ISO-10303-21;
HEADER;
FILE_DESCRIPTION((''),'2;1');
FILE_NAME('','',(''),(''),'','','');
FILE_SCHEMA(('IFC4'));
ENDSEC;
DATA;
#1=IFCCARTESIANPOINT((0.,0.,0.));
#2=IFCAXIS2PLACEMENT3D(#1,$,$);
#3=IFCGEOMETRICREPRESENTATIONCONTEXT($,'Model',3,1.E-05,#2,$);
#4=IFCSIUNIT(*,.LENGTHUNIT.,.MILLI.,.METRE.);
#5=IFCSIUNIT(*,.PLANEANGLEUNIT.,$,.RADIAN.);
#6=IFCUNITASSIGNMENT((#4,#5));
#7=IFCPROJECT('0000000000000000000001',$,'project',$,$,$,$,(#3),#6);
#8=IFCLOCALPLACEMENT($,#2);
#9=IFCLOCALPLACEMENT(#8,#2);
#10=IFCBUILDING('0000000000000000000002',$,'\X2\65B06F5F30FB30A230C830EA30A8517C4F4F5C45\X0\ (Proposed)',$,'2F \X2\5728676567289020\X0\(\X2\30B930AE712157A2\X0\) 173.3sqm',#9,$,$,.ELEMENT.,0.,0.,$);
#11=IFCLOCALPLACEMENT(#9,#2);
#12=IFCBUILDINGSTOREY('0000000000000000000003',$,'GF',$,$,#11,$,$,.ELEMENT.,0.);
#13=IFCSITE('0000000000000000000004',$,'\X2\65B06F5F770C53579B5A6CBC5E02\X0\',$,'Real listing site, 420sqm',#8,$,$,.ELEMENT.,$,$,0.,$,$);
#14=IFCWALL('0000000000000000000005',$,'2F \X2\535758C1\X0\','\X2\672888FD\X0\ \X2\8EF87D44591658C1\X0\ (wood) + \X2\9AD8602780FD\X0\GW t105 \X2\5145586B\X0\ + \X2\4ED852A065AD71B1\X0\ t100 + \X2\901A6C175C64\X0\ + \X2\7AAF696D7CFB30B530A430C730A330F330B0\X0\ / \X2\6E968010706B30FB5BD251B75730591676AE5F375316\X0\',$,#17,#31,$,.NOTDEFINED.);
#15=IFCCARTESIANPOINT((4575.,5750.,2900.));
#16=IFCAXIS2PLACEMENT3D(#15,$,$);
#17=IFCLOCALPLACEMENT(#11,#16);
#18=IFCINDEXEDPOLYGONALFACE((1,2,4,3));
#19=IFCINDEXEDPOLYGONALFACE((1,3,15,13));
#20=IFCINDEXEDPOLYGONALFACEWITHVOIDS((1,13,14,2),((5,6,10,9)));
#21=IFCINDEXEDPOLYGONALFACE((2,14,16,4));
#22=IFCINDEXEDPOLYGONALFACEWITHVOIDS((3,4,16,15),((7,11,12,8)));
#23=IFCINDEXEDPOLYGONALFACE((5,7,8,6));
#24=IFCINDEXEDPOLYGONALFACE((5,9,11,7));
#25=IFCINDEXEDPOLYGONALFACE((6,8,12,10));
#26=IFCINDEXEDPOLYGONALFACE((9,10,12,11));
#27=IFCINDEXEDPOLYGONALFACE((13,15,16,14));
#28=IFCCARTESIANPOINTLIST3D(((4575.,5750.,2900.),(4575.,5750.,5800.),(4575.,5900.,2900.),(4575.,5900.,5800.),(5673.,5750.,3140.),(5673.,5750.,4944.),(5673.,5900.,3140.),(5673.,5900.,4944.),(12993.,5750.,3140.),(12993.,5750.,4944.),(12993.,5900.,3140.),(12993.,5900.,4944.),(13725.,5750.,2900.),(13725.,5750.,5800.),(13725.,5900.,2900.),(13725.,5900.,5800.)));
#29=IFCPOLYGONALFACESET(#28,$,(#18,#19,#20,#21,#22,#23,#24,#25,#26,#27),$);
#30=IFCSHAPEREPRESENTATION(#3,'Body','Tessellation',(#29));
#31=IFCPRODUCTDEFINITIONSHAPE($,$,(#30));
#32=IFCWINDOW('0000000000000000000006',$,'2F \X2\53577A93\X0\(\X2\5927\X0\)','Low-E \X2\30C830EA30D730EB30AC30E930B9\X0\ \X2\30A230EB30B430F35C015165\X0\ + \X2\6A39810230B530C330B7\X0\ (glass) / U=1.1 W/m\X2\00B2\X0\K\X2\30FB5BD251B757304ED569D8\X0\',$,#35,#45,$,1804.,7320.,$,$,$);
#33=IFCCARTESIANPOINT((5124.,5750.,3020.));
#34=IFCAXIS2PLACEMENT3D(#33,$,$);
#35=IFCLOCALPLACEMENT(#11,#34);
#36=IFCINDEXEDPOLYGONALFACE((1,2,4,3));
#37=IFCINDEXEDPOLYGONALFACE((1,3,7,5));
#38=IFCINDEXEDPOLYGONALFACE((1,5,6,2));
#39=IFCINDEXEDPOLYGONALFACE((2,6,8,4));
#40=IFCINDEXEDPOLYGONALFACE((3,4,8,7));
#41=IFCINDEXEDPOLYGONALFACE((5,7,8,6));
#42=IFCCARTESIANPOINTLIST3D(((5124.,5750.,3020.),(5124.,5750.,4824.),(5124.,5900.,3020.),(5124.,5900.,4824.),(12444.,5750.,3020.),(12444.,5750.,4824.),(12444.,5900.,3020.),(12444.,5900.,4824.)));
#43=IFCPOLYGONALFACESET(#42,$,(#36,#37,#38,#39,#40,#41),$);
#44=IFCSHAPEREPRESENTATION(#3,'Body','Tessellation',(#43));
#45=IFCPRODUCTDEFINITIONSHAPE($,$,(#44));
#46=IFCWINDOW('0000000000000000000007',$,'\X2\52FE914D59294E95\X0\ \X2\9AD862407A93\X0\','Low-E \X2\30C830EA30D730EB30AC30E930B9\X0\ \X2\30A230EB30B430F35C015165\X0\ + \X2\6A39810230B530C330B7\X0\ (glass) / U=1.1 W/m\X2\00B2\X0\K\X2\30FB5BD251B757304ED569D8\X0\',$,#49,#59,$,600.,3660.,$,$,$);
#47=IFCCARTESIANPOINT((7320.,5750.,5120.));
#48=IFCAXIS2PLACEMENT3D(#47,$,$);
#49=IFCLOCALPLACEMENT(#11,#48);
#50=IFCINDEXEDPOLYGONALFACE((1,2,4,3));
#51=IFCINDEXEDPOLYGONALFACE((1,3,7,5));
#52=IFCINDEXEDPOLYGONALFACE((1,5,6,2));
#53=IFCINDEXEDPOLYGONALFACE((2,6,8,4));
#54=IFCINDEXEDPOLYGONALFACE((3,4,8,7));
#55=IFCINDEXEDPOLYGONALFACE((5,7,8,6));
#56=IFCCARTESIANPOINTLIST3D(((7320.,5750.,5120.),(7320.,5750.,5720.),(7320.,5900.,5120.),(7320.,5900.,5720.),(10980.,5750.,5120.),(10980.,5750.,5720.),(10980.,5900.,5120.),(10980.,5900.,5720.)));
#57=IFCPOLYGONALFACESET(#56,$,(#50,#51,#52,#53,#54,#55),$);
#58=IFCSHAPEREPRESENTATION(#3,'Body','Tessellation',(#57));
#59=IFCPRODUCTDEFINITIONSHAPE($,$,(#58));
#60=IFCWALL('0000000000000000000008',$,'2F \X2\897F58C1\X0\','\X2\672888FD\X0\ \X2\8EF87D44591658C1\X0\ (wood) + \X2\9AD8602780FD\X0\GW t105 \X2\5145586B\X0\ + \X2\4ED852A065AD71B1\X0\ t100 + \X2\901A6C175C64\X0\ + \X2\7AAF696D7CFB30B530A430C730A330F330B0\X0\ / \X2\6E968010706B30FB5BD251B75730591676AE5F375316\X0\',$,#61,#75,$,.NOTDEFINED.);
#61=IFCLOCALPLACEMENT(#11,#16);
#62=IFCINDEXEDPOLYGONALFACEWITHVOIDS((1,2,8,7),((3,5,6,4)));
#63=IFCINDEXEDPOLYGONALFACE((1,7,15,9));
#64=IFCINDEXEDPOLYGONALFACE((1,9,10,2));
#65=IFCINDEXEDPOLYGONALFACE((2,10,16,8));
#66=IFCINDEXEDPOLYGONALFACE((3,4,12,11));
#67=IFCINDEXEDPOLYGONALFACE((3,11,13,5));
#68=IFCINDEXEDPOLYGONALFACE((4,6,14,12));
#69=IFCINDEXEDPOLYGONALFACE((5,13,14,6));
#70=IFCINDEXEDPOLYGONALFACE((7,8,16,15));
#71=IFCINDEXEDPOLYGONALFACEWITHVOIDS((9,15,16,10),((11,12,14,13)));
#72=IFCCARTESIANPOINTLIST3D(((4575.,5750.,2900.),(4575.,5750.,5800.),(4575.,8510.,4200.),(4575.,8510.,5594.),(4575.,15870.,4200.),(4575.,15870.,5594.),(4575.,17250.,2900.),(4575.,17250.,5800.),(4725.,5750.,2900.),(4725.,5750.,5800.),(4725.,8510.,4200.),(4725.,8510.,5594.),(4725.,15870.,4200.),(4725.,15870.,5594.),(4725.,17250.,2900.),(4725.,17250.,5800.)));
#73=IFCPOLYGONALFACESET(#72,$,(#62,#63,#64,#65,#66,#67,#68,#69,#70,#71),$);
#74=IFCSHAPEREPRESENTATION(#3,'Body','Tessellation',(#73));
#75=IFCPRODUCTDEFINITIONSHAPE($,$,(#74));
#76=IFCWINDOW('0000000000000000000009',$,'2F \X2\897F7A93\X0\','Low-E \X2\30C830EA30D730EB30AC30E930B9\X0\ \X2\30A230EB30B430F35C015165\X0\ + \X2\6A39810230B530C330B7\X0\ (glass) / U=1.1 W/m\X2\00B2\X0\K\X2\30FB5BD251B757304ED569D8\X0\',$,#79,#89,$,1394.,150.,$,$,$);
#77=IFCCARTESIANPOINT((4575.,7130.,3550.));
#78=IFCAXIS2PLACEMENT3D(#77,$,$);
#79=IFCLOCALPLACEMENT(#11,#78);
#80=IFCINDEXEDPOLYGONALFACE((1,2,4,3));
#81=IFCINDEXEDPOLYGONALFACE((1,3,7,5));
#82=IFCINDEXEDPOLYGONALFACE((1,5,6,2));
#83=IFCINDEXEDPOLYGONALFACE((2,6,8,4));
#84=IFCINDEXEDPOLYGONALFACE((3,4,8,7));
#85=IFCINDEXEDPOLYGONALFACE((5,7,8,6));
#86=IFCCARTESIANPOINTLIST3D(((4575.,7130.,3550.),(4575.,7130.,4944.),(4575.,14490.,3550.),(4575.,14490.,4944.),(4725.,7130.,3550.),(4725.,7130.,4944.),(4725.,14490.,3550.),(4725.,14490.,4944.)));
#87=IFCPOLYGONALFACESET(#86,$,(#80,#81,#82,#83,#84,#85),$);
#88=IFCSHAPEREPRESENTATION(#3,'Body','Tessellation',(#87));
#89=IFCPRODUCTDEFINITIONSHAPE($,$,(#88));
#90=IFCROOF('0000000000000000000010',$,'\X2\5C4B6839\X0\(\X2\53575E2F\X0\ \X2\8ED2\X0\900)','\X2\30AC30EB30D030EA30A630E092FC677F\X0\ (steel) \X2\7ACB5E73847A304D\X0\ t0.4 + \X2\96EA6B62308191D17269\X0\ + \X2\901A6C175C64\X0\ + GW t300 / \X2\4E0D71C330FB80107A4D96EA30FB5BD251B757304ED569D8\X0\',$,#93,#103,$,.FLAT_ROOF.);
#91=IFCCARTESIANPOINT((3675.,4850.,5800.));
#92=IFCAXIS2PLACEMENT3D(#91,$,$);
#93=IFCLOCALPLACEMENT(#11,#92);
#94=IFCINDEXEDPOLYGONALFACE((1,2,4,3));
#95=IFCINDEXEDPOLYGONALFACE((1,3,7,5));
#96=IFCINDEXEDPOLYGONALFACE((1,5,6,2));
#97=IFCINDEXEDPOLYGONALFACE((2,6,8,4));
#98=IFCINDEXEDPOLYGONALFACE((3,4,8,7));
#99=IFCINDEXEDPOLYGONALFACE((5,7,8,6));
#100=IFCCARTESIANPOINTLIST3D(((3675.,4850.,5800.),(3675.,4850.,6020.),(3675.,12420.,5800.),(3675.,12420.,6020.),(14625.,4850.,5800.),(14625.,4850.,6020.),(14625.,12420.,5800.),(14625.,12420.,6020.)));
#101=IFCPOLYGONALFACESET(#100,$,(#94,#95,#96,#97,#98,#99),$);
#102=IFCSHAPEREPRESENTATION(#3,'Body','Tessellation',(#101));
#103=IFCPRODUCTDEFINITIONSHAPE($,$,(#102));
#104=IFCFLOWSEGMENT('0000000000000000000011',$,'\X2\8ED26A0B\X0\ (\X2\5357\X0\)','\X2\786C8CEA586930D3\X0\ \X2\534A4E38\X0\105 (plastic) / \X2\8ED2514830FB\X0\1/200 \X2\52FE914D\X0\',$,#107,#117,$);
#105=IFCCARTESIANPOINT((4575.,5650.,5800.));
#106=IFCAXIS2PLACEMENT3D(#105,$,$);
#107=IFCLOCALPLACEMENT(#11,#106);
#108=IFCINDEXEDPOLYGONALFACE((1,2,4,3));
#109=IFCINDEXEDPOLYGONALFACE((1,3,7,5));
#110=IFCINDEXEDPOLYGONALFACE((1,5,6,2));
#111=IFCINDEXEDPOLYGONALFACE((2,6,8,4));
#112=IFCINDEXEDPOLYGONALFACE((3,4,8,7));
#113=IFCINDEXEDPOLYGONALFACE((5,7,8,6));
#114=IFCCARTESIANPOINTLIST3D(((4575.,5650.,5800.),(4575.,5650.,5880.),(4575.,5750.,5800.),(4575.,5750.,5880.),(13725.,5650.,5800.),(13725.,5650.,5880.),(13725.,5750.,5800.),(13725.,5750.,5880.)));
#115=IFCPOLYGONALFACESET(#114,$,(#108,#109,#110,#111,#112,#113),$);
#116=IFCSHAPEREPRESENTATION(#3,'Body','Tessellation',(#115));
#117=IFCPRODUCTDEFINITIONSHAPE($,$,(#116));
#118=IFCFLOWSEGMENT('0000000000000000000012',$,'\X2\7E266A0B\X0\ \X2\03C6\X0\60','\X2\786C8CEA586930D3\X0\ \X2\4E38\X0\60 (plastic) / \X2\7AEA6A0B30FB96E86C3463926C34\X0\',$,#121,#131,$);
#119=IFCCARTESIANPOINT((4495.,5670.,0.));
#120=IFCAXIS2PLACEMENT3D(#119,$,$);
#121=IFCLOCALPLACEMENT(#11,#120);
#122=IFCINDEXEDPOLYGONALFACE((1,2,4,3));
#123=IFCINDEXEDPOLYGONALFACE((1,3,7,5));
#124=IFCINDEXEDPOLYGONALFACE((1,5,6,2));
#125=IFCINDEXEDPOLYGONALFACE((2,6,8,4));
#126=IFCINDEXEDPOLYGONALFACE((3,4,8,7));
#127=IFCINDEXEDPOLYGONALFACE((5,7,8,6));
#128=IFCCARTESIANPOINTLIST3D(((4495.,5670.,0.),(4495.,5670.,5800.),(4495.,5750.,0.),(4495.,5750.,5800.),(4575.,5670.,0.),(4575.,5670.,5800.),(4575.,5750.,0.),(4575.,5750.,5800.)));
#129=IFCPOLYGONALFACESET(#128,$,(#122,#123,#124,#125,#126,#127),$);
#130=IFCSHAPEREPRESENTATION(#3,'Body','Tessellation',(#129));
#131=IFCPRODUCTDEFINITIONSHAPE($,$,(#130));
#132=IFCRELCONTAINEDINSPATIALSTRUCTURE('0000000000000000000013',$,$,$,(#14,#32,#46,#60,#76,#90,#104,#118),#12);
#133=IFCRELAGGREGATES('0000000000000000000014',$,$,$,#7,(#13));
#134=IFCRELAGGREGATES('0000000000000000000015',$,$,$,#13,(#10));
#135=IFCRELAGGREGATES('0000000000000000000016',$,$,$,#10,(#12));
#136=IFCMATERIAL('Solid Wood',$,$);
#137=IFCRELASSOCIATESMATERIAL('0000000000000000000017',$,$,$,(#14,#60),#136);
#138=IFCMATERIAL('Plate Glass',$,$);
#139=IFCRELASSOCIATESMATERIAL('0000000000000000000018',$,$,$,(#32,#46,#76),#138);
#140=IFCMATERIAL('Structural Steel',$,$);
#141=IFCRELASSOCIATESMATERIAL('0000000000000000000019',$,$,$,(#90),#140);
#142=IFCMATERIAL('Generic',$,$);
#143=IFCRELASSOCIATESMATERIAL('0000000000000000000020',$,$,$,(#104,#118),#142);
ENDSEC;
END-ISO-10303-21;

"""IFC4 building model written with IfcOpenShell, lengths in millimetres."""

from ifc_helpers import new_model, si_unit, frame, frame_2d, origin, place, context, project, spatial, rectangle, extrude, material, element, fill, save


model = new_model("IFC4")

# Units and contexts
model_context = context("Model", 3, precision=1e-05, world=origin())
ifc_project = project(units=[si_unit("LENGTHUNIT", "METRE", prefix="MILLI"), si_unit("PLANEANGLEUNIT", "RADIAN")], contexts=[model_context])

# Site, building, storey
site_placement = place(None, origin())
site = spatial("IfcSite", under=ifc_project, at=site_placement, Name="新潟県南魚沼市", ObjectType="Real listing site, 420sqm", CompositionType="ELEMENT", RefElevation=0.0)
building_placement = place(site_placement, origin())
building = spatial("IfcBuilding", under=site, at=building_placement, Name="新潟・アトリエ兼住居 (Proposed)", ObjectType="2F 在来木造(スギ無垢) 173.3sqm", CompositionType="ELEMENT", ElevationOfRefHeight=0.0, ElevationOfTerrain=0.0)
storey_placement = place(building_placement, origin())
storey = spatial("IfcBuildingStorey", under=building, at=storey_placement, Name="GF", CompositionType="ELEMENT", Elevation=0.0)

# Shared definitions
ifc_material_1 = material(Name="Solid Wood")

# Shared definitions
ifc_material_2 = material(Name="Plate Glass")

# Wall, openings, windows
wall_1_placement = place(storey_placement, frame((4575.0, 5750.0, 2900.0)))
wall_1 = element("IfcWall", 1, at=wall_1_placement, inside=storey, material=ifc_material_1, Name="2F 南壁", Description="木製 軸組外壁 (wood) + 高性能GW t105 充填 + 付加断熱 t100 + 通気層 + 窯業系サイディング / 準耐火・寒冷地外皮強化", PredefinedType="NOTDEFINED", context=model_context, shape_type="SweptSolid", body=[
    extrude(rectangle(XDim=9150.0, YDim=150.0, at=frame_2d((4575.0, 75.0))), frame((4575.0, 5750.0, 2900.0)), (0.0, 0.0, 1.0), 2900.0),
])
opening_1_placement = place(storey_placement, frame((5124.0, 5750.0, 3020.0)))
opening_1 = element("IfcOpeningElement", 2, at=opening_1_placement, cuts=wall_1, PredefinedType="NOTDEFINED", context=model_context, shape_type="SweptSolid", body=[
    extrude(rectangle(XDim=7320.0, YDim=150.0, at=frame_2d((3660.0, 75.0))), frame((5124.0, 5750.0, 3020.0)), (0.0, 0.0, 1.0), 1804.0),
])
opening_2_placement = place(storey_placement, frame((7320.0, 5750.0, 5120.0)))
opening_2 = element("IfcOpeningElement", 3, at=opening_2_placement, cuts=wall_1, PredefinedType="NOTDEFINED", context=model_context, shape_type="SweptSolid", body=[
    extrude(rectangle(XDim=3660.0, YDim=150.0, at=frame_2d((1830.0, 75.0))), frame((7320.0, 5750.0, 5120.0)), (0.0, 0.0, 1.0), 600.0),
])
window_1_placement = place(storey_placement, frame((5124.0, 5750.0, 3020.0)))
window_1 = element("IfcWindow", 4, at=window_1_placement, inside=storey, material=ifc_material_2, Name="2F 南窓(大)", Description="Low-E トリプルガラス アルゴン封入 + 樹脂サッシ (glass) / U=1.1 W/m²K・寒冷地仕様", OverallHeight=1804.0, OverallWidth=7320.0, context=model_context, shape_type="SweptSolid", body=[
    extrude(rectangle(XDim=7320.0, YDim=150.0, at=frame_2d((3660.0, 75.0))), frame((5124.0, 5750.0, 3020.0)), (0.0, 0.0, 1.0), 1804.0),
])
fill(opening_1, window_1)
window_2_placement = place(storey_placement, frame((7320.0, 5750.0, 5120.0)))
window_2 = element("IfcWindow", 5, at=window_2_placement, inside=storey, material=ifc_material_2, Name="勾配天井 高所窓", Description="Low-E トリプルガラス アルゴン封入 + 樹脂サッシ (glass) / U=1.1 W/m²K・寒冷地仕様", OverallHeight=600.0, OverallWidth=3660.0, context=model_context, shape_type="SweptSolid", body=[
    extrude(rectangle(XDim=3660.0, YDim=150.0, at=frame_2d((1830.0, 75.0))), frame((7320.0, 5750.0, 5120.0)), (0.0, 0.0, 1.0), 600.0),
])
fill(opening_2, window_2)

# Wall, opening, window
wall_2_placement = place(storey_placement, frame((4575.0, 5750.0, 2900.0)))
wall_2 = element("IfcWall", 6, at=wall_2_placement, inside=storey, material=ifc_material_1, Name="2F 西壁", Description="木製 軸組外壁 (wood) + 高性能GW t105 充填 + 付加断熱 t100 + 通気層 + 窯業系サイディング / 準耐火・寒冷地外皮強化", PredefinedType="NOTDEFINED", context=model_context, shape_type="SweptSolid", body=[
    extrude(rectangle(XDim=150.0, YDim=11500.0, at=frame_2d((75.0, 5750.0))), frame((4575.0, 5750.0, 2900.0)), (0.0, 0.0, 1.0), 2900.0),
])
opening_3_placement = place(storey_placement, frame((4575.0, 7130.0, 3550.0)))
opening_3 = element("IfcOpeningElement", 7, at=opening_3_placement, cuts=wall_2, PredefinedType="NOTDEFINED", context=model_context, shape_type="SweptSolid", body=[
    extrude(rectangle(XDim=150.0, YDim=7360.0, at=frame_2d((75.0, 3680.0))), frame((4575.0, 7130.0, 3550.0)), (0.0, 0.0, 1.0), 1394.0),
])
window_3_placement = place(storey_placement, frame((4575.0, 7130.0, 3550.0)))
window_3 = element("IfcWindow", 8, at=window_3_placement, inside=storey, material=ifc_material_2, Name="2F 西窓", Description="Low-E トリプルガラス アルゴン封入 + 樹脂サッシ (glass) / U=1.1 W/m²K・寒冷地仕様", OverallHeight=1394.0, OverallWidth=150.0, context=model_context, shape_type="SweptSolid", body=[
    extrude(rectangle(XDim=150.0, YDim=7360.0, at=frame_2d((75.0, 3680.0))), frame((4575.0, 7130.0, 3550.0)), (0.0, 0.0, 1.0), 1394.0),
])
fill(opening_3, window_3)

# Roof
ifc_material_3 = material(Name="Structural Steel")
for number, where, name in (
    (9, (3675.0, 4850.0, 5800.0), "屋根(南帯 軒900)"),
):
    element("IfcRoof", number, at=place(storey_placement, frame(where)), inside=storey, material=ifc_material_3, Name=name, Description="ガルバリウム鋼板 (steel) 立平葺き t0.4 + 雪止め金物 + 通気層 + GW t300 / 不燃・耐積雪・寒冷地仕様", PredefinedType="FLAT_ROOF", context=model_context, shape_type="SweptSolid", body=[
        extrude(rectangle(XDim=10950.0, YDim=7570.0, at=frame_2d((5475.0, 3785.0))), frame((3675.0, 4850.0, 5800.0)), (0.0, 0.0, 1.0), 220.0),
    ])

# Flow segments
ifc_material_4 = material(Name="Generic")
flow_segment_1_placement = place(storey_placement, frame((4575.0, 5650.0, 5800.0)))
element("IfcFlowSegment", 10, at=flow_segment_1_placement, inside=storey, material=ifc_material_4, Name="軒樋 (南)", Description="硬質塩ビ 半丸105 (plastic) / 軒先・1/200 勾配", context=model_context, shape_type="SweptSolid", body=[
    extrude(rectangle(XDim=9150.0, YDim=100.0, at=frame_2d((4575.0, 50.0))), frame((4575.0, 5650.0, 5800.0)), (0.0, 0.0, 1.0), 80.0),
])
flow_segment_2_placement = place(storey_placement, frame((4495.0, 5670.0, 0.0)))
element("IfcFlowSegment", 11, at=flow_segment_2_placement, inside=storey, material=ifc_material_4, Name="縦樋 φ60", Description="硬質塩ビ 丸60 (plastic) / 竪樋・雨水排水", context=model_context, shape_type="SweptSolid", body=[
    extrude(rectangle(XDim=80.0, YDim=80.0, at=frame_2d((40.0, 40.0))), frame((4495.0, 5670.0, 0.0)), (0.0, 0.0, 1.0), 5800.0),
])

save(model, "model.ifc")
